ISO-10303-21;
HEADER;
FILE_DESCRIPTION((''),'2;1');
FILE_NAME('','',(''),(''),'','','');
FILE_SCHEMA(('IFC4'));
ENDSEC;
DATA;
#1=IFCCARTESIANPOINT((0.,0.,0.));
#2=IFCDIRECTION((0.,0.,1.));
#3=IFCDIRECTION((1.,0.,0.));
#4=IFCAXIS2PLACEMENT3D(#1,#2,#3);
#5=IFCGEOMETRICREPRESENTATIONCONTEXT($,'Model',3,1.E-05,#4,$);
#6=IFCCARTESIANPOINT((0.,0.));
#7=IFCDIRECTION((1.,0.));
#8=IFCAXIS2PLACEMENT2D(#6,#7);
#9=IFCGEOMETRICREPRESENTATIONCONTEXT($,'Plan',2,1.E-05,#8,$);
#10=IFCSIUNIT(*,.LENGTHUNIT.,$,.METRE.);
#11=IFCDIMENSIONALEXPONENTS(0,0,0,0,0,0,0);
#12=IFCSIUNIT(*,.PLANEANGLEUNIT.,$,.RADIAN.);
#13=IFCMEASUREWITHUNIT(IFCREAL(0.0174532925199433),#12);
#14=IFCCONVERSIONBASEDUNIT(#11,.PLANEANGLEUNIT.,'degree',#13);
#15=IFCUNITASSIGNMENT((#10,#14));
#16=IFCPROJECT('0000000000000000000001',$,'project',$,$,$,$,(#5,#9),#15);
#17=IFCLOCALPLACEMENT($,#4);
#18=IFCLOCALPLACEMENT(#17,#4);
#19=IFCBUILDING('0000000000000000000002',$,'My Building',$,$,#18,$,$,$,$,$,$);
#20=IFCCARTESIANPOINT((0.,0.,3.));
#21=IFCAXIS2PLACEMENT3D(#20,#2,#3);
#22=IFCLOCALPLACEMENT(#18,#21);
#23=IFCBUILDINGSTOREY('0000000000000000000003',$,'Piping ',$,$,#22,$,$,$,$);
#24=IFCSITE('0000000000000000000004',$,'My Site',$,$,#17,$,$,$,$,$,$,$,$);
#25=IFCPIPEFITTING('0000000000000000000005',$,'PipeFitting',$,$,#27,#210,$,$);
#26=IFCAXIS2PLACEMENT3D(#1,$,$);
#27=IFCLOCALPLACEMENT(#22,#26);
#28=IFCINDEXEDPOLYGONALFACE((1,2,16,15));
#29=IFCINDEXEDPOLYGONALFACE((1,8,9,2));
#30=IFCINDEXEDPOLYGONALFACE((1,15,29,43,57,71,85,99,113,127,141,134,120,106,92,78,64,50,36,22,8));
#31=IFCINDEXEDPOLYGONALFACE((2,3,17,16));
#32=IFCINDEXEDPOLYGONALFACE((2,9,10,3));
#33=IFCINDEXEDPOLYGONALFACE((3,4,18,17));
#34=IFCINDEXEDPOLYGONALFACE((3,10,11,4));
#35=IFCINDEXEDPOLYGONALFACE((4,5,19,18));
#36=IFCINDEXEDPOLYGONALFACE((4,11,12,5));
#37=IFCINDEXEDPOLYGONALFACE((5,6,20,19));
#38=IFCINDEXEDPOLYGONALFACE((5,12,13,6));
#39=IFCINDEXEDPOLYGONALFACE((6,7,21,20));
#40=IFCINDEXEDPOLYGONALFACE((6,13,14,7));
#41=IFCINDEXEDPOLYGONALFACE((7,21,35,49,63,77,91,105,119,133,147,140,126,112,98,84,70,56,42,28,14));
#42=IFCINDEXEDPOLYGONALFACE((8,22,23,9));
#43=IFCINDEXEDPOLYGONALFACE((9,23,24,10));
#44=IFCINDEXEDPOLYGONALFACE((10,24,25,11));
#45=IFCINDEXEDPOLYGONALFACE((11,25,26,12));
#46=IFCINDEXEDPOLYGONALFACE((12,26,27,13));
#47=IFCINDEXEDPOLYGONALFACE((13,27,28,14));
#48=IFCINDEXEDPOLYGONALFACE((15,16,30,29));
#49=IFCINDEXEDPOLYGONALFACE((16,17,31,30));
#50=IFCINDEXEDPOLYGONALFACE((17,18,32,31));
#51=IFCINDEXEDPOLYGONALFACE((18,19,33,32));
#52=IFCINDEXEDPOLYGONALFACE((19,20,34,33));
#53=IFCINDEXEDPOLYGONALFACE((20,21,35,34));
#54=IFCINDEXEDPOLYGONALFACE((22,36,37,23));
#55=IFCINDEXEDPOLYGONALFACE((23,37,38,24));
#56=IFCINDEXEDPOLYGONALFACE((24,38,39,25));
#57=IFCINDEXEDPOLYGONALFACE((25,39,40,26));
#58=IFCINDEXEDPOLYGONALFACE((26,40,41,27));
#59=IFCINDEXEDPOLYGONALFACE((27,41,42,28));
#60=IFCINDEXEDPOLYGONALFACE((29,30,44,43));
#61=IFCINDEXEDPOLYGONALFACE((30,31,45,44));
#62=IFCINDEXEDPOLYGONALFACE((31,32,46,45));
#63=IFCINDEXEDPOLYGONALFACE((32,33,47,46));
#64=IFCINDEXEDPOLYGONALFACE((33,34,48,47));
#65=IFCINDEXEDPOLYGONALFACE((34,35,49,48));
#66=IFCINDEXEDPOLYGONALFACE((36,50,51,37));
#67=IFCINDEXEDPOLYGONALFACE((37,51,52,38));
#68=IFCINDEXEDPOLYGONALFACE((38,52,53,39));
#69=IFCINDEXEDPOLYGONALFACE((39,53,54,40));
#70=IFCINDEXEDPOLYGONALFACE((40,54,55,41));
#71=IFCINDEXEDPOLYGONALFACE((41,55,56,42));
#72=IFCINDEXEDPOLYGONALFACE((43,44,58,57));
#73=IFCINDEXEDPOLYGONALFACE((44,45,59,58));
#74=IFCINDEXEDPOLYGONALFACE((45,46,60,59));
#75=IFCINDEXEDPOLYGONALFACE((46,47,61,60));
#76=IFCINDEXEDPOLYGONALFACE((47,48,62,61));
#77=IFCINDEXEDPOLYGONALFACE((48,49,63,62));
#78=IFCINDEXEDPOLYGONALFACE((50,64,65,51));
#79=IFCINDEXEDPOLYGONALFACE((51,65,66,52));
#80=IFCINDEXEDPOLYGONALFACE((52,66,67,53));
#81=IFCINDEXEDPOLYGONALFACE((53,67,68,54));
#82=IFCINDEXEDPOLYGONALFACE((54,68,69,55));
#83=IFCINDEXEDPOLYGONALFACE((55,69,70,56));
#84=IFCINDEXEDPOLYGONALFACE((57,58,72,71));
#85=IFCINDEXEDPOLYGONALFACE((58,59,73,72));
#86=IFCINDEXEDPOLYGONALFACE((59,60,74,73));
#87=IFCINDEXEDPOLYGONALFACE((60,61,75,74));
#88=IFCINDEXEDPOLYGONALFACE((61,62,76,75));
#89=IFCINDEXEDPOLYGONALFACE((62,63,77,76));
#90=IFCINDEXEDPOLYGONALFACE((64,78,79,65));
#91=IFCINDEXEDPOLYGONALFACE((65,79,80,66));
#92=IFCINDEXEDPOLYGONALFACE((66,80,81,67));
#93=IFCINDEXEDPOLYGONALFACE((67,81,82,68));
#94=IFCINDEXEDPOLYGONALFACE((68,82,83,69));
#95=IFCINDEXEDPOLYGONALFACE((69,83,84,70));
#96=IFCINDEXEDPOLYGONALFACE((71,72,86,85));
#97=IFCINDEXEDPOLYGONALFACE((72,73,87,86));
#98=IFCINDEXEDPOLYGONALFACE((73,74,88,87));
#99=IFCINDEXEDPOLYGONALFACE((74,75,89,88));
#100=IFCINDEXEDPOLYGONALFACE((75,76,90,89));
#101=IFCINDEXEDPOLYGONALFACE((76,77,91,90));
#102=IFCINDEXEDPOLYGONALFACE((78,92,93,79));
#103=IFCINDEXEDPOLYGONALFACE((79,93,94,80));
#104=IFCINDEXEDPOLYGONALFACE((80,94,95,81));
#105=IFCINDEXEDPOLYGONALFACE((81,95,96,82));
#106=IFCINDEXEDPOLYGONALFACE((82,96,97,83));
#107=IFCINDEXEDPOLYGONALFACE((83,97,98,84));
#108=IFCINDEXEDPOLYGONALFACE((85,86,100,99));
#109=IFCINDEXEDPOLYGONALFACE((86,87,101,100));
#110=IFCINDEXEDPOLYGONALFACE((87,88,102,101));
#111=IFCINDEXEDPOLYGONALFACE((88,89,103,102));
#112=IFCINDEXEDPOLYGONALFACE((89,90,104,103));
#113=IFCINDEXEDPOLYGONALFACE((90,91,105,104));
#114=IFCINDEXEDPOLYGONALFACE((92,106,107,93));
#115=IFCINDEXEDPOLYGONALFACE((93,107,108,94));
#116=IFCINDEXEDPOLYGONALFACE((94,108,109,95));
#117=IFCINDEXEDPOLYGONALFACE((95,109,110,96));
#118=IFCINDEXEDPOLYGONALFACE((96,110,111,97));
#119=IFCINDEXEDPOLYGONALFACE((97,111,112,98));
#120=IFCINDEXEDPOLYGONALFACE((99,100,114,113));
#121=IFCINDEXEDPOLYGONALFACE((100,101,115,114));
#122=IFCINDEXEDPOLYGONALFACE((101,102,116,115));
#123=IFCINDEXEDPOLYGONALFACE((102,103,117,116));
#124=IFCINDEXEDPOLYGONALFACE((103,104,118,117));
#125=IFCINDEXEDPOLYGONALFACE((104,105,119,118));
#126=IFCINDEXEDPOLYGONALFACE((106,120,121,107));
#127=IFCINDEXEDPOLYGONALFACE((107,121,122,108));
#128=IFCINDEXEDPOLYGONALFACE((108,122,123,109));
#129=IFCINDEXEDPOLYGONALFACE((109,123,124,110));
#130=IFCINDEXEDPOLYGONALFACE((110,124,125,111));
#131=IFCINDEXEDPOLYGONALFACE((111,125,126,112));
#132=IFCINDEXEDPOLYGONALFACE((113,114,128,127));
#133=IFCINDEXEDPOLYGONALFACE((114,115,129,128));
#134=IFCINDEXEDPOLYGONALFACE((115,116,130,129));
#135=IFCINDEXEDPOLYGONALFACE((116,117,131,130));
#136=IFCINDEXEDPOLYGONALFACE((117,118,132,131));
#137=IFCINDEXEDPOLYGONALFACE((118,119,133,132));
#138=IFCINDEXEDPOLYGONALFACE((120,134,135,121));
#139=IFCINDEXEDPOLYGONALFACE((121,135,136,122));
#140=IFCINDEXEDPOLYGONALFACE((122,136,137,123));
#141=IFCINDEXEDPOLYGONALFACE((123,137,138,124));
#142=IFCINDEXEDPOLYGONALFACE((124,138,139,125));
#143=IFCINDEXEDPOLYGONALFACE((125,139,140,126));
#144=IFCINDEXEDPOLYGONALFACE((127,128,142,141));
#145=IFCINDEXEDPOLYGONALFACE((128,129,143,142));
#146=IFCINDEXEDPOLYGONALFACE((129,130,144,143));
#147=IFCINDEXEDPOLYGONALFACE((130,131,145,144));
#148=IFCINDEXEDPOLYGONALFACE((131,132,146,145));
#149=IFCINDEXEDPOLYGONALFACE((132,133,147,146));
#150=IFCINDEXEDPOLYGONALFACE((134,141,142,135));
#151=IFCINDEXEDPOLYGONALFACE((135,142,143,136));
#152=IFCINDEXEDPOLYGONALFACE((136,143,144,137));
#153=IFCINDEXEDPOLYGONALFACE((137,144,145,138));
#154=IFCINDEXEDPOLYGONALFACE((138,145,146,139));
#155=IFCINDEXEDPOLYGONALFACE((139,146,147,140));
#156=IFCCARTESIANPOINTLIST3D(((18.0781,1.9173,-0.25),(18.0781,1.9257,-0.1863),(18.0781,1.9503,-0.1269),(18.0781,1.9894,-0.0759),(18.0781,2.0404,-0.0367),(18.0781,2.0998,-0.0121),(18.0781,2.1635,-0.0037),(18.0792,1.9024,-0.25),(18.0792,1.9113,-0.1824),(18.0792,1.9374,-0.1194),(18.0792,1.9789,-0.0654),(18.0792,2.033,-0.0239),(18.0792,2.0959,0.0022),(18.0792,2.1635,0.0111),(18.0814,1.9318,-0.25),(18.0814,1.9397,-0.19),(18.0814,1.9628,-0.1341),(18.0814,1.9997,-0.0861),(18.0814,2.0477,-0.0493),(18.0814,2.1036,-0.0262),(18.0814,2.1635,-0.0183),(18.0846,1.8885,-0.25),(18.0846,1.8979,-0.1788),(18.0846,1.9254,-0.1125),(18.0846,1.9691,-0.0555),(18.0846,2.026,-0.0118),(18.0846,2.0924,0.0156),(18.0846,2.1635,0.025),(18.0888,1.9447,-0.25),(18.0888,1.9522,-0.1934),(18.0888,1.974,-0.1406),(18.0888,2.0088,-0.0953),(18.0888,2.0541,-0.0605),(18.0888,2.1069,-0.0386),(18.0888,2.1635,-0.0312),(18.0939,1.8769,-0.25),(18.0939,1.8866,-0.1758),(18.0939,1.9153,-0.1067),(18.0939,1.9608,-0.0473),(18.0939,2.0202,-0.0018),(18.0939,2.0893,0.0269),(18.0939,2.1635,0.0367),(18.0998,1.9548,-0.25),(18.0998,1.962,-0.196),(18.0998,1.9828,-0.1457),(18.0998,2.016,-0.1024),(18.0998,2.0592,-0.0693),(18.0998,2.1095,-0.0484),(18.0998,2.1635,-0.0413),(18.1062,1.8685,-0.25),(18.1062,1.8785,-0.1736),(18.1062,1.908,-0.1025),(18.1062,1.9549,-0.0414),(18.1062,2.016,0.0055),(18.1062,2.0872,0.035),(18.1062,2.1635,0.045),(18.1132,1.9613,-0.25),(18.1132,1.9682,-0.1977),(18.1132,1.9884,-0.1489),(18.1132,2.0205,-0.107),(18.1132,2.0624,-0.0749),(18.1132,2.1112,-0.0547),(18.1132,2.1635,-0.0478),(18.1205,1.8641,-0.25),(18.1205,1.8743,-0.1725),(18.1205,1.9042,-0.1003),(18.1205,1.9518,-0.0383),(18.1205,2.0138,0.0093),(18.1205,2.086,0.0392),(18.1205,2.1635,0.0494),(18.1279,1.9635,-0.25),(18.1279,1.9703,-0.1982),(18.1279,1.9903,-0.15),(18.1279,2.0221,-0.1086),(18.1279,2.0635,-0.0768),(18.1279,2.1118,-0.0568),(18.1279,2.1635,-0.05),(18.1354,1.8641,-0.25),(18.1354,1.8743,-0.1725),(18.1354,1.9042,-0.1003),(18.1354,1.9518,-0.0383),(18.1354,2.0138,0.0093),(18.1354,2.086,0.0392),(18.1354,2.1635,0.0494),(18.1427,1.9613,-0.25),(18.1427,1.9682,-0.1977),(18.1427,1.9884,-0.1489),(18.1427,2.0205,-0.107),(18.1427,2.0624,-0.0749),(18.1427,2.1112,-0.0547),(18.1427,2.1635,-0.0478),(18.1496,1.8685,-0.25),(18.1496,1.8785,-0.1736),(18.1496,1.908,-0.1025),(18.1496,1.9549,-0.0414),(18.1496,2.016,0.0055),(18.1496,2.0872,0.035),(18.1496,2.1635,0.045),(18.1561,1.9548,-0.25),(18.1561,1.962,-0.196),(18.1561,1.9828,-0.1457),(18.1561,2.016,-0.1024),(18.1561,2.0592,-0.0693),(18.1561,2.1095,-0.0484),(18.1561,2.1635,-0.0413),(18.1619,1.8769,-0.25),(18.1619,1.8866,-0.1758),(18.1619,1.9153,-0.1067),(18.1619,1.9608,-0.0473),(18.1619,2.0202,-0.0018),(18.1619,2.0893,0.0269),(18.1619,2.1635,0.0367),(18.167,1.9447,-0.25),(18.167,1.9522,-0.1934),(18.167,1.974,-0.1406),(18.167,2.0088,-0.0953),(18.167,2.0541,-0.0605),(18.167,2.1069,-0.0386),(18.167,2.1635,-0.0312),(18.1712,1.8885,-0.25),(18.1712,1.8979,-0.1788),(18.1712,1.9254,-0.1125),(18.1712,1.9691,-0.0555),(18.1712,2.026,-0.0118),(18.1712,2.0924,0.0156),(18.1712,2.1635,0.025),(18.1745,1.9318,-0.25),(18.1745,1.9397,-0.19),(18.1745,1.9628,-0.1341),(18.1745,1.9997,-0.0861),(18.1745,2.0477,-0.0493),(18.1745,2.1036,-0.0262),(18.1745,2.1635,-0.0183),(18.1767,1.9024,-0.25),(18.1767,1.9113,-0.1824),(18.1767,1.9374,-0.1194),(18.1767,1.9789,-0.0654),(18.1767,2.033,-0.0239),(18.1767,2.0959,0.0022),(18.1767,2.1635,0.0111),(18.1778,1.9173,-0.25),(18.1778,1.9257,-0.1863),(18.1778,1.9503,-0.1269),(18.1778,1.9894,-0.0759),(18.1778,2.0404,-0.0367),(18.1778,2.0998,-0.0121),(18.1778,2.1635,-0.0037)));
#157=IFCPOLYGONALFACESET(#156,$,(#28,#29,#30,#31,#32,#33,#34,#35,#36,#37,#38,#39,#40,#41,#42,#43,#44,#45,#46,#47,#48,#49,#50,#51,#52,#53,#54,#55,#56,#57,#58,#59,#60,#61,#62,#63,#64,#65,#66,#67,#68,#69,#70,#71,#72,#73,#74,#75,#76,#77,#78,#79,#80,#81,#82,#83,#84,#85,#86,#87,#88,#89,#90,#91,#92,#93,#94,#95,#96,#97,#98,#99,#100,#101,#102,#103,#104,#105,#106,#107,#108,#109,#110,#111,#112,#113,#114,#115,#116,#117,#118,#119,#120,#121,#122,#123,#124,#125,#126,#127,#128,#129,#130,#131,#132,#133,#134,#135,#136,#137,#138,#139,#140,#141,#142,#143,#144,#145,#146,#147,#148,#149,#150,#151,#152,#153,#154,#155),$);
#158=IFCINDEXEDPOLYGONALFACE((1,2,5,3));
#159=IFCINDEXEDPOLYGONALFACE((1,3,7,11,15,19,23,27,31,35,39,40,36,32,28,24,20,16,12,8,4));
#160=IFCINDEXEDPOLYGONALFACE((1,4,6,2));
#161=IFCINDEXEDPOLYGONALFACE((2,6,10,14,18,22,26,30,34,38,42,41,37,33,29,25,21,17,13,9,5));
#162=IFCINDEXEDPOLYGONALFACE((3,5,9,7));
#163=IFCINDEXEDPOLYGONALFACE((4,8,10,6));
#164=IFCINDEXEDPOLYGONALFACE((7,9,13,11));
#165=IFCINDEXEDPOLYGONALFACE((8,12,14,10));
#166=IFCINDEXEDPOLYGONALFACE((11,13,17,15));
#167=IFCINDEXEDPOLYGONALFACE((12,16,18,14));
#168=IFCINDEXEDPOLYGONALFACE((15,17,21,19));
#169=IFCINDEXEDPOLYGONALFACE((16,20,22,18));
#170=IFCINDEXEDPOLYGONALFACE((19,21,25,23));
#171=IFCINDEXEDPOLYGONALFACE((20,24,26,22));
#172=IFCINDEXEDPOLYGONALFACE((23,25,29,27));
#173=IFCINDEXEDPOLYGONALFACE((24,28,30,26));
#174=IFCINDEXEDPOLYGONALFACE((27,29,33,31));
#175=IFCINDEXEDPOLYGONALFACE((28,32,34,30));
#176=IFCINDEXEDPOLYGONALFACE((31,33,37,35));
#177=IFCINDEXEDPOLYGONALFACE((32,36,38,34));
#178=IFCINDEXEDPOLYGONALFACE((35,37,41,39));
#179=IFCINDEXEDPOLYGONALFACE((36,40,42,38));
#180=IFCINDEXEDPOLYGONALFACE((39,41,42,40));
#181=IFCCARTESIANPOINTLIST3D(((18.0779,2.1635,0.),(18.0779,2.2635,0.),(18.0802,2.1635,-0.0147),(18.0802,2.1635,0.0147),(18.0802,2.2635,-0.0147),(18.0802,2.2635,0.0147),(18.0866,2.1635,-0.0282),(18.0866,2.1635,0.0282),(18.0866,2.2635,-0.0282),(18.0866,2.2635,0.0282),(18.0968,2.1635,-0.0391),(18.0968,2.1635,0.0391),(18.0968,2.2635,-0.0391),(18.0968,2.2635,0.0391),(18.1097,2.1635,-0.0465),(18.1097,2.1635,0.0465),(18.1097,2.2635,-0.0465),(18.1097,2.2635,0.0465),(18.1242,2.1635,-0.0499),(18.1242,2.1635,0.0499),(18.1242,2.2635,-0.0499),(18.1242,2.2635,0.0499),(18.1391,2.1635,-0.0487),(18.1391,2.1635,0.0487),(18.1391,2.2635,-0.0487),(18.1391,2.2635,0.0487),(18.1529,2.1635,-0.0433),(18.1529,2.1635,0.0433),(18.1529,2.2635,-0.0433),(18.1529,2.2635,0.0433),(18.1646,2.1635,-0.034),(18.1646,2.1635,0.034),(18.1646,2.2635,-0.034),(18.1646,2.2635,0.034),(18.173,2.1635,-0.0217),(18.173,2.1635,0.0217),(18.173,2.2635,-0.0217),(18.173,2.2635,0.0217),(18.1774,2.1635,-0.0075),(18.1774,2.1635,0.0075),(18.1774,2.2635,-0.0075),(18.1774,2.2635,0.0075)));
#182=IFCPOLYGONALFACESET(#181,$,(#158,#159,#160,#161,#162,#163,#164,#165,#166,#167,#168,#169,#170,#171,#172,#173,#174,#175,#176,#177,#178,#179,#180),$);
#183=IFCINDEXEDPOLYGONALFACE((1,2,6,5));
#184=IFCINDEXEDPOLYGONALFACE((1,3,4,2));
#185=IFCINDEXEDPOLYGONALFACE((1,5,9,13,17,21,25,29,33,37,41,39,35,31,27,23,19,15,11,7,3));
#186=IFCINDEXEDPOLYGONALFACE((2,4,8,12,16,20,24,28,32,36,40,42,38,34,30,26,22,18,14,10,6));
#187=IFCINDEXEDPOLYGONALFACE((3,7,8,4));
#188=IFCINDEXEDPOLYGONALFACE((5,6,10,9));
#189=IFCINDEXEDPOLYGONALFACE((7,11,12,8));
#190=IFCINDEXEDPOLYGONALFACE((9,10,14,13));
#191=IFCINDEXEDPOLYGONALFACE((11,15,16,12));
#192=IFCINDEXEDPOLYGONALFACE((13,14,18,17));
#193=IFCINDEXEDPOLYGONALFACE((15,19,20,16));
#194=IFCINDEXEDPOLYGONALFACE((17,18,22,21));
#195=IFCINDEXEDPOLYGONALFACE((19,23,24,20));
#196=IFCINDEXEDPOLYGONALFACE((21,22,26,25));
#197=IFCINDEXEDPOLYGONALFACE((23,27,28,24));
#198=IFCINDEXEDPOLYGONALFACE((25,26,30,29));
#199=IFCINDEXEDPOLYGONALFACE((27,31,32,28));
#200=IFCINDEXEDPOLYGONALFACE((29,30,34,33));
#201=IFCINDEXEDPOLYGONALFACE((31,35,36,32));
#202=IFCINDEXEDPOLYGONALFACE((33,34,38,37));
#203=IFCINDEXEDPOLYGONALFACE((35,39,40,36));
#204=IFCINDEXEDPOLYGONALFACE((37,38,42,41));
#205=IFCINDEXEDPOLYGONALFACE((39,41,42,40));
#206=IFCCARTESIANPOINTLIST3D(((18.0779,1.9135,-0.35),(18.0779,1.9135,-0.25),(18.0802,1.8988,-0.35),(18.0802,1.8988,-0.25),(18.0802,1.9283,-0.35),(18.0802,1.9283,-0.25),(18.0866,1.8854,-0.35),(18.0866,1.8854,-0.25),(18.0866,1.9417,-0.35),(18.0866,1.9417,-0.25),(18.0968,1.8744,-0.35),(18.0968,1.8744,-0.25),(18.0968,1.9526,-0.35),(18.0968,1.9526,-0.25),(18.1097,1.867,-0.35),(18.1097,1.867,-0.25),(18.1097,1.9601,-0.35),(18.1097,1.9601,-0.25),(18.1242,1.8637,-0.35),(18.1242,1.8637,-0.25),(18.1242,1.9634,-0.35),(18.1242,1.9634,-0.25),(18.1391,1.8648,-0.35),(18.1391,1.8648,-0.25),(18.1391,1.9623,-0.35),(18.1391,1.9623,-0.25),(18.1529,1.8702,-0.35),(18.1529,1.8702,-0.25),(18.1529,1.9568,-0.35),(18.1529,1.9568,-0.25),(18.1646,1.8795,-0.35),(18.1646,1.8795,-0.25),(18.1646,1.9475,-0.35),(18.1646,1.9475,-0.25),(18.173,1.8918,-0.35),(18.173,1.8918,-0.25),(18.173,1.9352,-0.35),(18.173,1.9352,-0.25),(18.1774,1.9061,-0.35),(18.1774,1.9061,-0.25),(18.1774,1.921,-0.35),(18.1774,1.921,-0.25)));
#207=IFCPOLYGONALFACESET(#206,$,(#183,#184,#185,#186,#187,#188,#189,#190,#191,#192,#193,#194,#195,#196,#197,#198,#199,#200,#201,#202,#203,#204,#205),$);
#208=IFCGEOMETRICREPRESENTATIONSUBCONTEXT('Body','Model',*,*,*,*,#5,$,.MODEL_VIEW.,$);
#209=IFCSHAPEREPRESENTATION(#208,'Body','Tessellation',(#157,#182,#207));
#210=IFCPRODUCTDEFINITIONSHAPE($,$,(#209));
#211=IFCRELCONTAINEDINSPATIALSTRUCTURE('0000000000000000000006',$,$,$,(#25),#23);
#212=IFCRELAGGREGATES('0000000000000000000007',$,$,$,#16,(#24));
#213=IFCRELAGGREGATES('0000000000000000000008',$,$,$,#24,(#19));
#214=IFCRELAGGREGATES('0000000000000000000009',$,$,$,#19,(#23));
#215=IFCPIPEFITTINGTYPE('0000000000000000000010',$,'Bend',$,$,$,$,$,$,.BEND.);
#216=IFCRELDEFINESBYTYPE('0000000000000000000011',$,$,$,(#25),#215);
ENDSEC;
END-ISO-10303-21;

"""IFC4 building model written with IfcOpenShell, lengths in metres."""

from ifc_helpers import new_model, entity, si_unit, converted_unit, frame, origin_with_axes, origin_2d_with_axis, place, context, subcontext, project, spatial, circle, extrude, source, transform, mapped, type_object, type_shapes, element, save


model = new_model("IFC4")

# Units and contexts
model_context = context("Model", 3, precision=1e-05, world=origin_with_axes())
plan_context = context("Plan", 2, precision=1e-05, world=origin_2d_with_axis())
body_context = subcontext(model_context, "Body", "Model", "MODEL_VIEW")
ifc_project = project(units=[si_unit("LENGTHUNIT", "METRE"), converted_unit("PLANEANGLEUNIT", "degree", entity("IfcReal", 0.0174532925199433), si_unit("PLANEANGLEUNIT", "RADIAN"), dimensions=[0, 0, 0, 0, 0, 0, 0])], contexts=[model_context, plan_context])

# Site, building, storey
site_placement = place(None, origin_with_axes())
site = spatial("IfcSite", under=ifc_project, at=site_placement, Name="My Site")
building_placement = place(site_placement, origin_with_axes())
building = spatial("IfcBuilding", under=site, at=building_placement, Name="My Building")
storey_placement = place(building_placement, frame((0.0, 0.0, 3.0), z_axis=(0.0, 0.0, 1.0), x_axis=(1.0, 0.0, 0.0)))
storey = spatial("IfcBuildingStorey", under=building, at=storey_placement, Name="Piping ")

# Pipe fitting
pipe_fitting_type = type_object("IfcPipeFittingType", Name="Bend", PredefinedType="BEND")
shared_shape = source(origin_with_axes(), body_context, "Body", "SolidModel", [
    entity("IfcSweptDiskSolid", entity("IfcIndexedPolyCurve", entity("IfcCartesianPointList3D", [[0.0, 0.0, -0.1], [0.0, -0.0732, -0.2768], [0.0, -0.25, -0.35]]), [entity("IfcArcIndex", [1, 2, 3])]), 0.05),
    extrude(circle(Radius=0.05), origin_with_axes(), (0.0, 0.0, -1.0), 0.1),
    extrude(circle(Radius=0.05), frame((0.0, -0.25, -0.35), z_axis=(0.0, -1.0, 0.0), x_axis=(1.0, 0.0, 0.0)), (0.0, 0.0, 1.0), 0.1),
])
type_shapes(pipe_fitting_type, [shared_shape])
for number, where, z_axis, x_axis, name in (
    (1, (18.1279, 2.2635, 0.0), (0.0, 1.0, 0.0), (-1.0, 0.0, 0.0), "PipeFitting"),
):
    element("IfcPipeFitting", number, at=place(storey_placement, frame(where, z_axis=z_axis, x_axis=x_axis)), inside=storey, type_object=pipe_fitting_type, Name=name, context=body_context, shape_type="MappedRepresentation", body=[
        mapped(shared_shape, transform((0.0, 0.0, 0.0), x_axis=(1.0, 0.0, 0.0), y_axis=(0.0, 1.0, 0.0), z_axis=(0.0, 0.0, 1.0), scale=1.0)),
    ])

save(model, "model.ifc")
